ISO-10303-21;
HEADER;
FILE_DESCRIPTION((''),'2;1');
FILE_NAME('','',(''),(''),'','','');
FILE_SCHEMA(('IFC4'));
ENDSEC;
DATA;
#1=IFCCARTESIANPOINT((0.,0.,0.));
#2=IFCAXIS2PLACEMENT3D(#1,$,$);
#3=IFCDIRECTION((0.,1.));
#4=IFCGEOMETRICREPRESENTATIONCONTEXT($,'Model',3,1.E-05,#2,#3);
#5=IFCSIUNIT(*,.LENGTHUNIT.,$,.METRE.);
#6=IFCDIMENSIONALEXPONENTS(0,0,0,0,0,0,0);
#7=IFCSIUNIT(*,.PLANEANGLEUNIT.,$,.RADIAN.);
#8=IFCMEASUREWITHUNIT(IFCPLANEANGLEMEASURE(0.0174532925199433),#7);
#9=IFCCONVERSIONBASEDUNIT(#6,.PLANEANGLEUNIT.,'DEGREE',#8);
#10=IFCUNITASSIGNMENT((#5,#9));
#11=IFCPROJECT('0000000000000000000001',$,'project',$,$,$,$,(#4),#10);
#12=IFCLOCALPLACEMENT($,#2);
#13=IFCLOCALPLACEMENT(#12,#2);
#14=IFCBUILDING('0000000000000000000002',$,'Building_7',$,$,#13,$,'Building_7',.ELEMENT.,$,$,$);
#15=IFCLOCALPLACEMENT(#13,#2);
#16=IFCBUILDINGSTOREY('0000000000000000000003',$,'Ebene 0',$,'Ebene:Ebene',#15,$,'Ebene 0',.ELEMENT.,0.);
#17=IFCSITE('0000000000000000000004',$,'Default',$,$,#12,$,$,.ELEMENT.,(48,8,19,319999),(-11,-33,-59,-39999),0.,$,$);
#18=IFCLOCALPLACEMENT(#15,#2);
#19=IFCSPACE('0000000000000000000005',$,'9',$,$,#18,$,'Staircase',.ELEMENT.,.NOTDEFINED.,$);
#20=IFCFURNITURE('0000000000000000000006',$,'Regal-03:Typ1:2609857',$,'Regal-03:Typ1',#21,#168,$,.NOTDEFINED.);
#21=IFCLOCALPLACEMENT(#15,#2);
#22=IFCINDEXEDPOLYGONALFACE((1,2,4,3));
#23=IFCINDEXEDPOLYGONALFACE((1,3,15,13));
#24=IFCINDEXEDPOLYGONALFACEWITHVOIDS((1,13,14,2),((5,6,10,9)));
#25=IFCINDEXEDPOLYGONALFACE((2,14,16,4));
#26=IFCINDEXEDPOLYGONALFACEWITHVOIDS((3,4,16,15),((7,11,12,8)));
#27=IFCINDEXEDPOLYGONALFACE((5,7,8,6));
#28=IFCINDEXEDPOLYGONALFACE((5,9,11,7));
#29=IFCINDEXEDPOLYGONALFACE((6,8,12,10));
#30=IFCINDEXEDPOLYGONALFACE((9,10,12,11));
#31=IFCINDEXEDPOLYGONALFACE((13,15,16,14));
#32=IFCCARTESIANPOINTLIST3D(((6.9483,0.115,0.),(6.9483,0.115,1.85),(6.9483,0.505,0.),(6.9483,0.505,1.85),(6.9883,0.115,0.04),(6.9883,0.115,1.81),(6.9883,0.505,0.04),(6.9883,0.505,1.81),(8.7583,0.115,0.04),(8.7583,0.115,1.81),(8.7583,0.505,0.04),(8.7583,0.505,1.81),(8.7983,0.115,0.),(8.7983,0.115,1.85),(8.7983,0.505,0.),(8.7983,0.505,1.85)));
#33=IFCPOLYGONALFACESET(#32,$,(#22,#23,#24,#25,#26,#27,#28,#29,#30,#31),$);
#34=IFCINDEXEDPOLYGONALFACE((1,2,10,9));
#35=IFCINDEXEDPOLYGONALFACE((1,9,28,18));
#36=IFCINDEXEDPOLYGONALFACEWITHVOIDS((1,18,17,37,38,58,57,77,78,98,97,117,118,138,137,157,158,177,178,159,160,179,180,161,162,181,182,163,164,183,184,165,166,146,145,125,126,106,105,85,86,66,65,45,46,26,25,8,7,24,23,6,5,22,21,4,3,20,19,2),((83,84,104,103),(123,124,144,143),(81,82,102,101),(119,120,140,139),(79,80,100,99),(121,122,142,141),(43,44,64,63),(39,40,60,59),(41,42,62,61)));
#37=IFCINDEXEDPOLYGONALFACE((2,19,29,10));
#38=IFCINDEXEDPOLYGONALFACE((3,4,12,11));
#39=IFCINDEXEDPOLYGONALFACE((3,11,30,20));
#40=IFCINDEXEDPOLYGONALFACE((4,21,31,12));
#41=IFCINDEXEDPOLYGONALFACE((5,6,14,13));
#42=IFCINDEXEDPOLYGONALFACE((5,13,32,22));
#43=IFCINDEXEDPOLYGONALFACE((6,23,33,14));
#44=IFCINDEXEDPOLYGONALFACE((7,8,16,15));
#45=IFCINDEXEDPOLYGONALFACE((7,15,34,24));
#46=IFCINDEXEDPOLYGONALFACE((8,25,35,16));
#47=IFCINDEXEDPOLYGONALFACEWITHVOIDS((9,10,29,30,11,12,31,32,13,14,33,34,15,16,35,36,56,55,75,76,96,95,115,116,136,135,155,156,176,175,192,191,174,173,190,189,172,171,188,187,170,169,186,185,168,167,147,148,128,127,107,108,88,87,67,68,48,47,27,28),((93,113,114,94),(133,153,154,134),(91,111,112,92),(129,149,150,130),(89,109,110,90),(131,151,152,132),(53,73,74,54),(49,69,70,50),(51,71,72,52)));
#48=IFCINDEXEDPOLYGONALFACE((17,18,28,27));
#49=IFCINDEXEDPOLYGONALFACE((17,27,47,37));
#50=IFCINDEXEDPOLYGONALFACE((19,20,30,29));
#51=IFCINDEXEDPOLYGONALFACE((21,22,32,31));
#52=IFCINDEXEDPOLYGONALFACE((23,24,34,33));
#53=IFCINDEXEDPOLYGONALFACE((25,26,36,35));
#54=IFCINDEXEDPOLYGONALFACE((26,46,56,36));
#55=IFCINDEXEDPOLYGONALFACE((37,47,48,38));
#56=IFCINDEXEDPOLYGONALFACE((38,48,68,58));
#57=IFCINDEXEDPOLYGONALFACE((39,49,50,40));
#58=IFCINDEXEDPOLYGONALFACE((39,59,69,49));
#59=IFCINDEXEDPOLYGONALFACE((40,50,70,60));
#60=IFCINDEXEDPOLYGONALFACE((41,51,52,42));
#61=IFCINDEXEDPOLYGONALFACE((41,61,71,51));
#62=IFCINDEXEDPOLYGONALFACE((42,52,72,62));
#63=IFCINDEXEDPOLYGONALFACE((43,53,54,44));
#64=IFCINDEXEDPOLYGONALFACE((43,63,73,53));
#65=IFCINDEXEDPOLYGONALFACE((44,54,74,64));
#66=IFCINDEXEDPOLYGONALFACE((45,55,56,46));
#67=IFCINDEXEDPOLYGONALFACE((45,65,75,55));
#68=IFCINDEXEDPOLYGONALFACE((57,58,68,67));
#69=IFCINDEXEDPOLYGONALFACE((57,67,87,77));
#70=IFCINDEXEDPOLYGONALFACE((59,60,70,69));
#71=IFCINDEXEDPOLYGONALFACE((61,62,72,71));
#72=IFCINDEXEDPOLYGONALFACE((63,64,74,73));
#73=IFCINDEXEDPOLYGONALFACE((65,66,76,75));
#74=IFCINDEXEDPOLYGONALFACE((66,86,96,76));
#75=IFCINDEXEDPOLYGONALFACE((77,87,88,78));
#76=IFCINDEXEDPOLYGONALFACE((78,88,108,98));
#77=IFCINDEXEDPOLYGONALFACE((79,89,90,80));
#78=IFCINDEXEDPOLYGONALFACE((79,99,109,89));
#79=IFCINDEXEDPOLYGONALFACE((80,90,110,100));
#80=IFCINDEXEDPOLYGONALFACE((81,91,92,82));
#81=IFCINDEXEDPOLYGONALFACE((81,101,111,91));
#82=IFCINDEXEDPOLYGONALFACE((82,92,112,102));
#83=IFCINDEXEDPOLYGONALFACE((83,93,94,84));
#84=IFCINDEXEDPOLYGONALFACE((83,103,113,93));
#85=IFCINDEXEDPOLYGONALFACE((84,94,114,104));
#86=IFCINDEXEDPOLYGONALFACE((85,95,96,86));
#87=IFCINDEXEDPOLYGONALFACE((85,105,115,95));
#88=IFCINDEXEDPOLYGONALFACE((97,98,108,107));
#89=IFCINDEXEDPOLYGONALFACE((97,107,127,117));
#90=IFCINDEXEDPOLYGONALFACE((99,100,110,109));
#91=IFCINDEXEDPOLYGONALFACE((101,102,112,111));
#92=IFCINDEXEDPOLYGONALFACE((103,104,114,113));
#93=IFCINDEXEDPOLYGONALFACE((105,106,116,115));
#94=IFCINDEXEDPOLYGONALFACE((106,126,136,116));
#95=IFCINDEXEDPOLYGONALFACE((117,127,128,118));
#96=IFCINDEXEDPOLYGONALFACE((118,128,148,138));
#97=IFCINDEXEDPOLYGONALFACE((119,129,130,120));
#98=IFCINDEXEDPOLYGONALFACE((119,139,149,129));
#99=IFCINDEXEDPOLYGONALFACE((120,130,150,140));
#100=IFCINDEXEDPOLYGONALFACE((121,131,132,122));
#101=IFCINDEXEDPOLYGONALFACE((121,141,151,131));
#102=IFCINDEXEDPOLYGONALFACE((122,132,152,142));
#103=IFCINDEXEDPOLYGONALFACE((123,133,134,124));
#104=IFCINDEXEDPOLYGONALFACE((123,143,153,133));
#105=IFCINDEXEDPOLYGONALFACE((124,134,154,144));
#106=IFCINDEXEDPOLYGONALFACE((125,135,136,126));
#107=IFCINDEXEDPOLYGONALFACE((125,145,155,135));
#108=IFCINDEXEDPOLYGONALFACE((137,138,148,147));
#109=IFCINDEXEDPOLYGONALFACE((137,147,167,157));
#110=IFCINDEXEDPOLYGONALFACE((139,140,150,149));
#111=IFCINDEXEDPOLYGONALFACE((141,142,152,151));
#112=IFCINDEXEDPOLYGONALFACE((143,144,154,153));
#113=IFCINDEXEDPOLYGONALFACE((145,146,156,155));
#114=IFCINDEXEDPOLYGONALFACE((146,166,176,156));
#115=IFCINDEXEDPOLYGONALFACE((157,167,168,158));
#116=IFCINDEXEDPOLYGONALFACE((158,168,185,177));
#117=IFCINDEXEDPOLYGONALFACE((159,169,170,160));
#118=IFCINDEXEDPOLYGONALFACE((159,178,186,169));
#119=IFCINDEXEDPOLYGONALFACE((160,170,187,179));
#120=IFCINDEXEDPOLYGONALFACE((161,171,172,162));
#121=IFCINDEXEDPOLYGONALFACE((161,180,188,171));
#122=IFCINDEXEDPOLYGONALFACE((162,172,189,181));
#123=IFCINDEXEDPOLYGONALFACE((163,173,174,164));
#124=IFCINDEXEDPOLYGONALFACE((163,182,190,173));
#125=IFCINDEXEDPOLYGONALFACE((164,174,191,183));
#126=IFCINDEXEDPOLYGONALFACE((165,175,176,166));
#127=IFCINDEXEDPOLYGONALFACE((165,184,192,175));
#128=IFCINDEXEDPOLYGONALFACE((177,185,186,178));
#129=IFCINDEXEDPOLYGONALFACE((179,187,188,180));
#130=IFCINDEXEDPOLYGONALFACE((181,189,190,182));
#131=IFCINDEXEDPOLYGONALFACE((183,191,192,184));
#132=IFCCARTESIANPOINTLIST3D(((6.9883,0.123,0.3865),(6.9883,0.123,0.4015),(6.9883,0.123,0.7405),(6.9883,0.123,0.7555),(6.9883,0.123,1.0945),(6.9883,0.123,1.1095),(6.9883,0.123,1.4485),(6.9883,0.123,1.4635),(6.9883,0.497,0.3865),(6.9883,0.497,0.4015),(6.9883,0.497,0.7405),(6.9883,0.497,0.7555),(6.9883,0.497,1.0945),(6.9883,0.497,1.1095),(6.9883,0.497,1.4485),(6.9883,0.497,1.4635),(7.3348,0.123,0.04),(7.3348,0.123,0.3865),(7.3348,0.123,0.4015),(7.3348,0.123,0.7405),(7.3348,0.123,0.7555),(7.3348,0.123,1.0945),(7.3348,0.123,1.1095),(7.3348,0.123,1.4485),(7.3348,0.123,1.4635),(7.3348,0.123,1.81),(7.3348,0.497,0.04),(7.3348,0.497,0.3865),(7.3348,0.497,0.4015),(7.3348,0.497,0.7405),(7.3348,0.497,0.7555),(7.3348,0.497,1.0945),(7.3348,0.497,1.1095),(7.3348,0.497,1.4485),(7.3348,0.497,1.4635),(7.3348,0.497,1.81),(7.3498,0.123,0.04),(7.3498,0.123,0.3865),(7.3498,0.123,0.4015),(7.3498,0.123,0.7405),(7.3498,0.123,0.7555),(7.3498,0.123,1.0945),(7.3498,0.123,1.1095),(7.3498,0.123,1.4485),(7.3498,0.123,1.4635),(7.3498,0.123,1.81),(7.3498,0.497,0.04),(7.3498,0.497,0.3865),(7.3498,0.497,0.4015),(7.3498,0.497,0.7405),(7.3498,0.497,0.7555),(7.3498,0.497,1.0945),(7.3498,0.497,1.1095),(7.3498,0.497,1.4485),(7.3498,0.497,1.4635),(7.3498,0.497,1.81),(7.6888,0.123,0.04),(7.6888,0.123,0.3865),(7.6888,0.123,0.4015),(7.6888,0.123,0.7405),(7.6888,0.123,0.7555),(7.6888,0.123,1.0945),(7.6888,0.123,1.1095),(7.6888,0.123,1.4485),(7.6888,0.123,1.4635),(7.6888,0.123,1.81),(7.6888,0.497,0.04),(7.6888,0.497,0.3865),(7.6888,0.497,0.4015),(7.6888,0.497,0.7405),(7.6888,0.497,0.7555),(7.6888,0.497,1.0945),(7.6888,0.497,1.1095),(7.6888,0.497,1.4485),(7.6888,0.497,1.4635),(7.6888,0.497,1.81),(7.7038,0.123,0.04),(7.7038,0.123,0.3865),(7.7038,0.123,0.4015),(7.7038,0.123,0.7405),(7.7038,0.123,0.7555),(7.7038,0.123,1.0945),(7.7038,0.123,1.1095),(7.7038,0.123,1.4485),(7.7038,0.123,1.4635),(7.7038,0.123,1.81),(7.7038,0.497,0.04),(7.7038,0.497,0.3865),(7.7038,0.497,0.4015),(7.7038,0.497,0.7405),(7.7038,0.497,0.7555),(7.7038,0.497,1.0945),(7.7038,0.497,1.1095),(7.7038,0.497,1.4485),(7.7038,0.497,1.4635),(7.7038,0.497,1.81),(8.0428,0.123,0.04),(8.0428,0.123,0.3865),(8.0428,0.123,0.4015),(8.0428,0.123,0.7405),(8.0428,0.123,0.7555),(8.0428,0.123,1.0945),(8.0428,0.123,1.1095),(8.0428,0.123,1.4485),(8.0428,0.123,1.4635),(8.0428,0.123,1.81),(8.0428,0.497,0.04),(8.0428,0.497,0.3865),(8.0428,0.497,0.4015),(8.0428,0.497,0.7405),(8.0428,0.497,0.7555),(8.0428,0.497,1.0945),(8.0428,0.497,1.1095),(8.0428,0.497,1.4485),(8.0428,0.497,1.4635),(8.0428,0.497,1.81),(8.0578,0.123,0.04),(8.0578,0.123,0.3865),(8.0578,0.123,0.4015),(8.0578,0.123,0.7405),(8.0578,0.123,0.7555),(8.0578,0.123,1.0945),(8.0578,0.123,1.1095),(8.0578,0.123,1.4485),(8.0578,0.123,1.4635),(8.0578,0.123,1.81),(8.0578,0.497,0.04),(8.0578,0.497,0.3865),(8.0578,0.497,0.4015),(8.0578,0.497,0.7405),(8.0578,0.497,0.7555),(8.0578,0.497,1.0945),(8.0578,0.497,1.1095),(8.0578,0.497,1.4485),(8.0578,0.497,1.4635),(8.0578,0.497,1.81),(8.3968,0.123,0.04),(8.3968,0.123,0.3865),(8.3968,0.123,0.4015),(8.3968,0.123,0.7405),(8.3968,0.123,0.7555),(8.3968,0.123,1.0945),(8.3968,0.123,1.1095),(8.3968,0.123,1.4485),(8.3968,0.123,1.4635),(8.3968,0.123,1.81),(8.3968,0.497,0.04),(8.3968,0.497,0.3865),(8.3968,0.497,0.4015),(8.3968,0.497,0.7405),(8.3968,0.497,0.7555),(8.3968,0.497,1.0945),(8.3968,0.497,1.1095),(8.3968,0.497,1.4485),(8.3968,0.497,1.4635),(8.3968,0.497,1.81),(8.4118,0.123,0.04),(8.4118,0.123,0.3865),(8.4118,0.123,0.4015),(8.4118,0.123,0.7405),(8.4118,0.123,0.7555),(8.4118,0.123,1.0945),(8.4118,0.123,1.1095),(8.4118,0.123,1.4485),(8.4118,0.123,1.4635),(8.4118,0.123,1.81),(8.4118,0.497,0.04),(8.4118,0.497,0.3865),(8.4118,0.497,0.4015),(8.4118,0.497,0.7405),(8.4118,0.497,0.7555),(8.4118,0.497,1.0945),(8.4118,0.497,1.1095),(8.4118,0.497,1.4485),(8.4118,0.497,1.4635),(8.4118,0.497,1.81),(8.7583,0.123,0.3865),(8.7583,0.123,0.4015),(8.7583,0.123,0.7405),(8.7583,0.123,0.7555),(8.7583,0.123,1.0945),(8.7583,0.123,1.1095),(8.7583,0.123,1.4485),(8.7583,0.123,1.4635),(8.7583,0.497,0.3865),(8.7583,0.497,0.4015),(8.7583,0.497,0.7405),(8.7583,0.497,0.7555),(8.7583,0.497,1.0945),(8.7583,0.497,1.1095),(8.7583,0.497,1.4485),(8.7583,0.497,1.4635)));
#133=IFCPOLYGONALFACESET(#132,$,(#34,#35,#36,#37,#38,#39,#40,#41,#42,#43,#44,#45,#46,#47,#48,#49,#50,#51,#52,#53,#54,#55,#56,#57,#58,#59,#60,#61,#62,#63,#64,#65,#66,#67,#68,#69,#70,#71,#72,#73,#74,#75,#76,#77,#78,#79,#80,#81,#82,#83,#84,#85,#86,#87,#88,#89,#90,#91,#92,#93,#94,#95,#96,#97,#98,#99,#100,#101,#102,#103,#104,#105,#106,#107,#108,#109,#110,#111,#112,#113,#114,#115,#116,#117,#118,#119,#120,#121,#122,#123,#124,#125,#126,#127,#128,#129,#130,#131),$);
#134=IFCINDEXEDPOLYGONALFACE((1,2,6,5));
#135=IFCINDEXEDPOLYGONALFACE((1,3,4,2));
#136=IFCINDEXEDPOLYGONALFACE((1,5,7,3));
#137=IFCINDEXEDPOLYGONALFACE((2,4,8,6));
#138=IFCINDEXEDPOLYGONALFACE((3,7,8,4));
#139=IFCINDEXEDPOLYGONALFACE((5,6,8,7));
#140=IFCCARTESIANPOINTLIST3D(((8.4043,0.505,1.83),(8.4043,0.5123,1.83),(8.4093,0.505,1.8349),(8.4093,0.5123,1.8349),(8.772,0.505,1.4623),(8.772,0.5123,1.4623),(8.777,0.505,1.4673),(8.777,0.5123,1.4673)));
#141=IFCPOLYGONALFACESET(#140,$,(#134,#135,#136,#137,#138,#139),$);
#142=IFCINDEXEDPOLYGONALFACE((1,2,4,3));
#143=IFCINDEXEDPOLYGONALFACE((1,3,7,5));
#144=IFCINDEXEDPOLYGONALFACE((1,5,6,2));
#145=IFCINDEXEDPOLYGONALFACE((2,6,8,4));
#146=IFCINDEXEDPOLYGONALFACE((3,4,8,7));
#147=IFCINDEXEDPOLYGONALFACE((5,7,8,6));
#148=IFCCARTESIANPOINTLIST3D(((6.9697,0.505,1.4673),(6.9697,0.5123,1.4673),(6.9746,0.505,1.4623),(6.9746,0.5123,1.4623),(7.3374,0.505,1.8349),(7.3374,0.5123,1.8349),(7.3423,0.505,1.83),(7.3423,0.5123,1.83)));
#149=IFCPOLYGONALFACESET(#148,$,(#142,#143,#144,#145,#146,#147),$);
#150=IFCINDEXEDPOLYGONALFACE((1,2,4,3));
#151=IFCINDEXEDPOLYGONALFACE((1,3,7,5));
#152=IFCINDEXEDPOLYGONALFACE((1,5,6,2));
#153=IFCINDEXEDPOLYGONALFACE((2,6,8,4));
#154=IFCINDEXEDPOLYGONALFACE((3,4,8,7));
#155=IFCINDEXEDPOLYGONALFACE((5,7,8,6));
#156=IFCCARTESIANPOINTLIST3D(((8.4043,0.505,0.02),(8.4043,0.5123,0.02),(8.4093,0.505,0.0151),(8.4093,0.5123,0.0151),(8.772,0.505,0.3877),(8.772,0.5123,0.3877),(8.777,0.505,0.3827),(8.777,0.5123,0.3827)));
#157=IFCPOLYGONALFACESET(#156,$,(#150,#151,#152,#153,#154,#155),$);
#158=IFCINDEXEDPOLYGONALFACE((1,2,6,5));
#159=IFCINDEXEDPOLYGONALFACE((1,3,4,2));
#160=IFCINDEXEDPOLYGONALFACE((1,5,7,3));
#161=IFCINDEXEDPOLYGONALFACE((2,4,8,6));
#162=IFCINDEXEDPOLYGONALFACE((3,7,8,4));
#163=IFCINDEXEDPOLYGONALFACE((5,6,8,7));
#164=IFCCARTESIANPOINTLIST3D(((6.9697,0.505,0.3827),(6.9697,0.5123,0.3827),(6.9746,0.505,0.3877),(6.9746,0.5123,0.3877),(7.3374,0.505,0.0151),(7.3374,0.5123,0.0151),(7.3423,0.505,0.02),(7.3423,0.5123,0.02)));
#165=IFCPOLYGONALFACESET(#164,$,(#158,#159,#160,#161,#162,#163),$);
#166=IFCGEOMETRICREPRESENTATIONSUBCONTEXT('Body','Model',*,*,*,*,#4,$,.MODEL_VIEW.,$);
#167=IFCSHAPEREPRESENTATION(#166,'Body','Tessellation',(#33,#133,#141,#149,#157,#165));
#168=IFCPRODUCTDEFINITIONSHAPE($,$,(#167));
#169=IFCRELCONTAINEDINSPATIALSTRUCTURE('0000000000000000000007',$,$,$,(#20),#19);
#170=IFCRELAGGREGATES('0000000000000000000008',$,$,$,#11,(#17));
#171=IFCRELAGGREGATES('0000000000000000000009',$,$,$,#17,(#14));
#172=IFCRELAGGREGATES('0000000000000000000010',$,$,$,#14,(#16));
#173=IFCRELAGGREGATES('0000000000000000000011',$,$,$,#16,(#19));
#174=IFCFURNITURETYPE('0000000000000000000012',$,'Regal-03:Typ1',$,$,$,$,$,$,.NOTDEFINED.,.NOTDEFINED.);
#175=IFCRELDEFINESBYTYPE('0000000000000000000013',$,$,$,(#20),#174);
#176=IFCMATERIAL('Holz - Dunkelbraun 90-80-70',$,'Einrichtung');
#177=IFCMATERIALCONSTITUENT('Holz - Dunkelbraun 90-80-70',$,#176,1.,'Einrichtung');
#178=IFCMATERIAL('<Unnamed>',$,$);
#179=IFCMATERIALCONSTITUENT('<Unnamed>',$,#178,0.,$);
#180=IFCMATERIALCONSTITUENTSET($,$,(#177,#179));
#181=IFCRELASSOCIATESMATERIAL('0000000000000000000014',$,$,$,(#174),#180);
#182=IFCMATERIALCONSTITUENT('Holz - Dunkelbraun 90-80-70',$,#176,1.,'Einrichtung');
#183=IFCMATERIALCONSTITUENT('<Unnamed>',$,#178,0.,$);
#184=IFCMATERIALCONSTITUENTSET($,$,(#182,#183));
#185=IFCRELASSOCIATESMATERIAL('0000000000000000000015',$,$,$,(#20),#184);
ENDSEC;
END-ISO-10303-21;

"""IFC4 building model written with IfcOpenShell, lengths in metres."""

from ifc_helpers import new_model, entity, si_unit, converted_unit, direction, frame, origin, place, context, subcontext, project, spatial, indexed_curve, outline, extrude, source, transform, mapped, material, constituent, constituent_set, type_object, type_shapes, element, save


model = new_model("IFC4")

# Units and contexts
model_context = context("Model", 3, precision=1e-05, world=origin(), true_north=direction((0.0, 1.0)))
body_context = subcontext(model_context, "Body", "Model", "MODEL_VIEW")
ifc_project = project(units=[si_unit("LENGTHUNIT", "METRE"), converted_unit("PLANEANGLEUNIT", "DEGREE", entity("IfcPlaneAngleMeasure", 0.0174532925199433), si_unit("PLANEANGLEUNIT", "RADIAN"), dimensions=[0, 0, 0, 0, 0, 0, 0])], contexts=[model_context])

# Site, building, storey
site_placement = place(None, origin())
site = spatial("IfcSite", under=ifc_project, at=site_placement, Name="Default", CompositionType="ELEMENT", RefLatitude=(48, 8, 19, 319999), RefLongitude=(-11, -33, -59, -39999), RefElevation=0.0)
building_placement = place(site_placement, origin())
building = spatial("IfcBuilding", under=site, at=building_placement, Name="Building_7", LongName="Building_7", CompositionType="ELEMENT")
storey_placement = place(building_placement, origin())
storey = spatial("IfcBuildingStorey", under=building, at=storey_placement, Name="Ebene 0", ObjectType="Ebene:Ebene", LongName="Ebene 0", CompositionType="ELEMENT", Elevation=0.0)

# Shared definitions
ifc_material_1 = material(Name="<Unnamed>")

# Shared definitions
ifc_material_2 = material(Name="Holz - Dunkelbraun 90-80-70", Category="Einrichtung")

# Shared definitions
space_1_placement = place(storey_placement, origin())
space_1 = spatial("IfcSpace", under=storey, at=space_1_placement, Name="9", LongName="Staircase", CompositionType="ELEMENT", PredefinedType="NOTDEFINED")

# Furniture
ifc_constituent_1 = constituent(ifc_material_2, Name="Holz - Dunkelbraun 90-80-70", Category="Einrichtung", fraction=1.0)
ifc_constituent_2 = constituent(ifc_material_1, Name="<Unnamed>", fraction=0.0)
ifc_constituent_set_1 = constituent_set(constituents=[ifc_constituent_1, ifc_constituent_2])
ifc_constituent_3 = constituent(ifc_material_2, Name="Holz - Dunkelbraun 90-80-70", Category="Einrichtung", fraction=1.0)
ifc_constituent_4 = constituent(ifc_material_1, Name="<Unnamed>", fraction=0.0)
ifc_constituent_set_2 = constituent_set(constituents=[ifc_constituent_3, ifc_constituent_4])
furniture_type_1 = type_object("IfcFurnitureType", Name="Regal-03:Typ1", AssemblyPlace="NOTDEFINED", PredefinedType="NOTDEFINED", material=ifc_constituent_set_2)
shared_shape_1 = source(origin(), body_context, "Body", "SweptSolid", [
    extrude(outline(indexed_curve([(-0.925, -0.925), (0.925, -0.925), (0.925, 0.925), (-0.925, 0.925), (-0.925, -0.925)], self_intersect=False), holes=[indexed_curve([(-0.885, -0.885), (-0.885, 0.885), (0.885, 0.885), (0.885, -0.885), (-0.885, -0.885)], self_intersect=False)]), frame((0.2471, -0.2651, 0.925), z_axis=(0.0, 1.0, 0.0), x_axis=(0.0, 0.0, -1.0)), (0.0, 0.0, 1.0), 0.39),
    extrude(outline(indexed_curve([(0.5385, -0.5385), (0.885, -0.5385), (0.885, -0.5235), (0.5385, -0.5235), (0.5385, -0.1845), (0.885, -0.1845), (0.885, -0.1695), (0.5385, -0.1695), (0.5385, 0.1695), (0.885, 0.1695), (0.885, 0.1845), (0.5385, 0.1845), (0.5385, 0.5235), (0.885, 0.5235), (0.885, 0.5385), (0.5385, 0.5385), (0.5385, 0.885), (0.5235, 0.885), (0.5235, 0.5385), (0.1845, 0.5385), (0.1845, 0.885), (0.1695, 0.885), (0.1695, 0.5385), (-0.1695, 0.5385), (-0.1695, 0.885), (-0.1845, 0.885), (-0.1845, 0.5385), (-0.5235, 0.5385), (-0.5235, 0.885), (-0.5385, 0.885), (-0.5385, 0.5385), (-0.885, 0.5385), (-0.885, 0.5235), (-0.5385, 0.5235), (-0.5385, 0.1845), (-0.885, 0.1845), (-0.885, 0.1695), (-0.5385, 0.1695), (-0.5385, -0.1695), (-0.885, -0.1695), (-0.885, -0.1845), (-0.5385, -0.1845), (-0.5385, -0.5235), (-0.885, -0.5235), (-0.885, -0.5385), (-0.5385, -0.5385), (-0.5385, -0.885), (-0.5235, -0.885), (-0.5235, -0.5385), (-0.1845, -0.5385), (-0.1845, -0.885), (-0.1695, -0.885), (-0.1695, -0.5385), (0.1695, -0.5385), (0.1695, -0.885), (0.1845, -0.885), (0.1845, -0.5385), (0.5235, -0.5385), (0.5235, -0.885), (0.5385, -0.885), (0.5385, -0.5385)], self_intersect=False), holes=[indexed_curve([(0.5235, -0.1845), (0.5235, -0.5235), (0.1845, -0.5235), (0.1845, -0.1845), (0.5235, -0.1845)], self_intersect=False), indexed_curve([(0.1845, -0.1695), (0.1845, 0.1695), (0.5235, 0.1695), (0.5235, -0.1695), (0.1845, -0.1695)], self_intersect=False), indexed_curve([(0.1845, 0.1845), (0.1845, 0.5235), (0.5235, 0.5235), (0.5235, 0.1845), (0.1845, 0.1845)], self_intersect=False), indexed_curve([(-0.1695, 0.5235), (0.1695, 0.5235), (0.1695, 0.1845), (-0.1695, 0.1845), (-0.1695, 0.5235)], self_intersect=False), indexed_curve([(-0.1695, 0.1695), (0.1695, 0.1695), (0.1695, -0.1695), (-0.1695, -0.1695), (-0.1695, 0.1695)], self_intersect=False), indexed_curve([(-0.1695, -0.1845), (0.1695, -0.1845), (0.1695, -0.5235), (-0.1695, -0.5235), (-0.1695, -0.1845)], self_intersect=False), indexed_curve([(-0.5235, -0.5235), (-0.5235, -0.1845), (-0.1845, -0.1845), (-0.1845, -0.5235), (-0.5235, -0.5235)], self_intersect=False), indexed_curve([(-0.5235, -0.1695), (-0.5235, 0.1695), (-0.1845, 0.1695), (-0.1845, -0.1695), (-0.5235, -0.1695)], self_intersect=False), indexed_curve([(-0.5235, 0.1845), (-0.5235, 0.5235), (-0.1845, 0.5235), (-0.1845, 0.1845), (-0.5235, 0.1845)], self_intersect=False)]), frame((0.2471, -0.2571, 0.925), z_axis=(0.0, 1.0, 0.0), x_axis=(0.0, 0.0, 1.0)), (0.0, 0.0, 1.0), 0.374),
    extrude(outline(indexed_curve([(-0.0037, -0.0035), (0.0037, -0.0035), (0.0037, 0.0035), (-0.0037, 0.0035), (-0.0037, -0.0035)], self_intersect=False)), frame((1.1482, 0.1286, 1.4648), z_axis=(-0.707107, 0.0, 0.707107), x_axis=(0.0, 1.0, 0.0)), (0.0, 0.0, 1.0), 0.52),
    extrude(outline(indexed_curve([(-0.0037, -0.0035), (0.0037, -0.0035), (0.0037, 0.0035), (-0.0037, 0.0035), (-0.0037, -0.0035)], self_intersect=False)), frame((-0.6541, 0.1286, 1.4648), z_axis=(0.707107, 0.0, 0.707107), x_axis=(0.0, 1.0, 0.0)), (0.0, 0.0, 1.0), 0.52),
    extrude(outline(indexed_curve([(-0.0037, -0.0035), (0.0037, -0.0035), (0.0037, 0.0035), (-0.0037, 0.0035), (-0.0037, -0.0035)], self_intersect=False)), frame((0.7805, 0.1286, 0.0175), z_axis=(0.707107, 0.0, 0.707107), x_axis=(0.0, 1.0, 0.0)), (0.0, 0.0, 1.0), 0.52),
    extrude(outline(indexed_curve([(-0.0037, -0.0035), (0.0037, -0.0035), (0.0037, 0.0035), (-0.0037, 0.0035), (-0.0037, -0.0035)], self_intersect=False)), frame((-0.2864, 0.1286, 0.0175), z_axis=(-0.707107, 0.0, 0.707107), x_axis=(0.0, 1.0, 0.0)), (0.0, 0.0, 1.0), 0.52),
])
type_shapes(furniture_type_1, [shared_shape_1])
furniture_1_placement = place(space_1_placement, frame((7.6263, 0.3801, 0.0)))
element("IfcFurniture", 1, at=furniture_1_placement, inside=space_1, type_object=furniture_type_1, material=ifc_constituent_set_1, Name="Regal-03:Typ1:2609857", ObjectType="Regal-03:Typ1", PredefinedType="NOTDEFINED", context=body_context, shape_type="MappedRepresentation", body=[
    mapped(shared_shape_1, transform((0.0, 0.0, 0.0), scale=1.0)),
])

save(model, "model.ifc")
